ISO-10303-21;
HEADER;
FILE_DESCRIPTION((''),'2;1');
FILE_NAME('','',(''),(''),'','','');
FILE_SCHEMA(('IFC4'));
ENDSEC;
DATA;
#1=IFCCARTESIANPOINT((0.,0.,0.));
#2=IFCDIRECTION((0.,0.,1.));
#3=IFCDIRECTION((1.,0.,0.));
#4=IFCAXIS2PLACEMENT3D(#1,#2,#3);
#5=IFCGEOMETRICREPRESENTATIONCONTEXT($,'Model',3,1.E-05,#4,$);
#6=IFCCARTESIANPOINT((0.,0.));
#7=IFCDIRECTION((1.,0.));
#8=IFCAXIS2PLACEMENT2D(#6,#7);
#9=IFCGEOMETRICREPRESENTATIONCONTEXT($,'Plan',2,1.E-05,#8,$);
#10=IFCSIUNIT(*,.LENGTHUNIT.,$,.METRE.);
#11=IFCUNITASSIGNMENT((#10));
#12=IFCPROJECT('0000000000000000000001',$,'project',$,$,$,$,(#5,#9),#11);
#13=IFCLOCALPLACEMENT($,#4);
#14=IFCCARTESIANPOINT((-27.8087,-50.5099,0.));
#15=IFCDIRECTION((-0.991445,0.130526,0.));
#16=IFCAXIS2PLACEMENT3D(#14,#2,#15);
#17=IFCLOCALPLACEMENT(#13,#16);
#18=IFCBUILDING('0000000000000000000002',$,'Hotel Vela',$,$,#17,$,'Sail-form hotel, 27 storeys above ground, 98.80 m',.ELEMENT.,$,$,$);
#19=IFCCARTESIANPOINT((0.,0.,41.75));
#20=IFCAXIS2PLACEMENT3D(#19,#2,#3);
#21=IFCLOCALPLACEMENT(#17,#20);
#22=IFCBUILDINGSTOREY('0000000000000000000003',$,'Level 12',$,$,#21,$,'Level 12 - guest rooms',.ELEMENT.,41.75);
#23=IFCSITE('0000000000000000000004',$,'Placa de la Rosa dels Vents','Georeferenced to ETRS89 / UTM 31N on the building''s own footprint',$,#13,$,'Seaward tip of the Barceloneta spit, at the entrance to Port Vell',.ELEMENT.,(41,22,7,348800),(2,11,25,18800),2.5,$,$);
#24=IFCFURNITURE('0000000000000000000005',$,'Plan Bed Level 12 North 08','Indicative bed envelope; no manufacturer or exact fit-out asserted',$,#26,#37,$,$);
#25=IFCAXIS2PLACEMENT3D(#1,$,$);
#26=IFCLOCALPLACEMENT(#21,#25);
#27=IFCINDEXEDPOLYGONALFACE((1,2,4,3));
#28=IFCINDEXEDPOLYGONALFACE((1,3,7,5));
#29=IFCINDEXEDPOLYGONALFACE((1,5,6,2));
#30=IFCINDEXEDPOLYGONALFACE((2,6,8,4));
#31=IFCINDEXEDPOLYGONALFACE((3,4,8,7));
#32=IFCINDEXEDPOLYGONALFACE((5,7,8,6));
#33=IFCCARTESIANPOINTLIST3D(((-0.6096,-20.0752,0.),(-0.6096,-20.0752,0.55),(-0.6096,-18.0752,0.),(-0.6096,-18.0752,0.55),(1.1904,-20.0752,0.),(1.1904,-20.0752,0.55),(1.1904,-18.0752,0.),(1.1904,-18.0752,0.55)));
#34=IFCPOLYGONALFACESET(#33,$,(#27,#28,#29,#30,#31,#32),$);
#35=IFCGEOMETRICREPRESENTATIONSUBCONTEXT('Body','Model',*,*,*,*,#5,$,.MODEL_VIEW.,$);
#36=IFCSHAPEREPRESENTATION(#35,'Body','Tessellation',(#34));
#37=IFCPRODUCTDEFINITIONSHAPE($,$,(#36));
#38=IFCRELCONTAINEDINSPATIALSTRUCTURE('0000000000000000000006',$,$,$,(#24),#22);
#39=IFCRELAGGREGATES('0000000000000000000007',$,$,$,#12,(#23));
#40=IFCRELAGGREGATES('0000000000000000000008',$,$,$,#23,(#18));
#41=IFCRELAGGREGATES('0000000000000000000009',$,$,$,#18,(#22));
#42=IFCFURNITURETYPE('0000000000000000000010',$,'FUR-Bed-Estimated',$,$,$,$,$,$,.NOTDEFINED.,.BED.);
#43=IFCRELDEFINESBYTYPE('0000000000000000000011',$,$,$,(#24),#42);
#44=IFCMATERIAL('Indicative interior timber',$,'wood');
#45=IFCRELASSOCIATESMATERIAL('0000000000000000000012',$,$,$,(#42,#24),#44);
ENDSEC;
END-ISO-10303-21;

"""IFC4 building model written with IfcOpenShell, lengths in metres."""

from ifc_helpers import new_model, si_unit, frame, origin_with_axes, origin_2d_with_axis, place, context, subcontext, project, spatial, line, indexed_curve, outline, extrude, material, type_object, element, save


model = new_model("IFC4")

# Units and contexts
model_context = context("Model", 3, precision=1e-05, world=origin_with_axes())
plan_context = context("Plan", 2, precision=1e-05, world=origin_2d_with_axis())
body_context = subcontext(model_context, "Body", "Model", "MODEL_VIEW")
ifc_project = project(units=[si_unit("LENGTHUNIT", "METRE")], contexts=[model_context, plan_context])

# Site, building, storey
site_placement = place(None, origin_with_axes())
site = spatial("IfcSite", under=ifc_project, at=site_placement, Name="Placa de la Rosa dels Vents", Description="Georeferenced to ETRS89 / UTM 31N on the building's own footprint", LongName="Seaward tip of the Barceloneta spit, at the entrance to Port Vell", CompositionType="ELEMENT", RefLatitude=(41, 22, 7, 348800), RefLongitude=(2, 11, 25, 18800), RefElevation=2.5)
building_placement = place(site_placement, frame((-27.8087, -50.5099, 0.0), z_axis=(0.0, 0.0, 1.0), x_axis=(-0.991445, 0.130526, 0.0)))
building = spatial("IfcBuilding", under=site, at=building_placement, Name="Hotel Vela", LongName="Sail-form hotel, 27 storeys above ground, 98.80 m", CompositionType="ELEMENT")
storey_placement = place(building_placement, frame((0.0, 0.0, 41.75), z_axis=(0.0, 0.0, 1.0), x_axis=(1.0, 0.0, 0.0)))
storey = spatial("IfcBuildingStorey", under=building, at=storey_placement, Name="Level 12", LongName="Level 12 - guest rooms", CompositionType="ELEMENT", Elevation=41.75)

# Shared definitions
ifc_material_1 = material(Name="Indicative interior timber", Category="wood")

# Furniture
furniture_type = type_object("IfcFurnitureType", Name="FUR-Bed-Estimated", AssemblyPlace="NOTDEFINED", PredefinedType="BED", material=ifc_material_1)
for number, where, z_axis, x_axis, name in (
    (1, (-0.6096, -20.0752, 0.0), (0.0, 0.0, 1.0), (1.0, 0.0, 0.0), "Plan Bed Level 12 North 08"),
):
    element("IfcFurniture", number, at=place(storey_placement, frame(where, z_axis=z_axis, x_axis=x_axis)), inside=storey, type_object=furniture_type, material=ifc_material_1, Name=name, Description="Indicative bed envelope; no manufacturer or exact fit-out asserted", context=body_context, shape_type="SweptSolid", body=[
        extrude(outline(indexed_curve([(0.0, 0.0), (1.8, 0.0), (1.8, 2.0), (0.0, 2.0)], segments=[line(1, 2, 3, 4, 1)])), origin_with_axes(), (0.0, 0.0, 1.0), 0.55),
    ])

save(model, "model.ifc")
